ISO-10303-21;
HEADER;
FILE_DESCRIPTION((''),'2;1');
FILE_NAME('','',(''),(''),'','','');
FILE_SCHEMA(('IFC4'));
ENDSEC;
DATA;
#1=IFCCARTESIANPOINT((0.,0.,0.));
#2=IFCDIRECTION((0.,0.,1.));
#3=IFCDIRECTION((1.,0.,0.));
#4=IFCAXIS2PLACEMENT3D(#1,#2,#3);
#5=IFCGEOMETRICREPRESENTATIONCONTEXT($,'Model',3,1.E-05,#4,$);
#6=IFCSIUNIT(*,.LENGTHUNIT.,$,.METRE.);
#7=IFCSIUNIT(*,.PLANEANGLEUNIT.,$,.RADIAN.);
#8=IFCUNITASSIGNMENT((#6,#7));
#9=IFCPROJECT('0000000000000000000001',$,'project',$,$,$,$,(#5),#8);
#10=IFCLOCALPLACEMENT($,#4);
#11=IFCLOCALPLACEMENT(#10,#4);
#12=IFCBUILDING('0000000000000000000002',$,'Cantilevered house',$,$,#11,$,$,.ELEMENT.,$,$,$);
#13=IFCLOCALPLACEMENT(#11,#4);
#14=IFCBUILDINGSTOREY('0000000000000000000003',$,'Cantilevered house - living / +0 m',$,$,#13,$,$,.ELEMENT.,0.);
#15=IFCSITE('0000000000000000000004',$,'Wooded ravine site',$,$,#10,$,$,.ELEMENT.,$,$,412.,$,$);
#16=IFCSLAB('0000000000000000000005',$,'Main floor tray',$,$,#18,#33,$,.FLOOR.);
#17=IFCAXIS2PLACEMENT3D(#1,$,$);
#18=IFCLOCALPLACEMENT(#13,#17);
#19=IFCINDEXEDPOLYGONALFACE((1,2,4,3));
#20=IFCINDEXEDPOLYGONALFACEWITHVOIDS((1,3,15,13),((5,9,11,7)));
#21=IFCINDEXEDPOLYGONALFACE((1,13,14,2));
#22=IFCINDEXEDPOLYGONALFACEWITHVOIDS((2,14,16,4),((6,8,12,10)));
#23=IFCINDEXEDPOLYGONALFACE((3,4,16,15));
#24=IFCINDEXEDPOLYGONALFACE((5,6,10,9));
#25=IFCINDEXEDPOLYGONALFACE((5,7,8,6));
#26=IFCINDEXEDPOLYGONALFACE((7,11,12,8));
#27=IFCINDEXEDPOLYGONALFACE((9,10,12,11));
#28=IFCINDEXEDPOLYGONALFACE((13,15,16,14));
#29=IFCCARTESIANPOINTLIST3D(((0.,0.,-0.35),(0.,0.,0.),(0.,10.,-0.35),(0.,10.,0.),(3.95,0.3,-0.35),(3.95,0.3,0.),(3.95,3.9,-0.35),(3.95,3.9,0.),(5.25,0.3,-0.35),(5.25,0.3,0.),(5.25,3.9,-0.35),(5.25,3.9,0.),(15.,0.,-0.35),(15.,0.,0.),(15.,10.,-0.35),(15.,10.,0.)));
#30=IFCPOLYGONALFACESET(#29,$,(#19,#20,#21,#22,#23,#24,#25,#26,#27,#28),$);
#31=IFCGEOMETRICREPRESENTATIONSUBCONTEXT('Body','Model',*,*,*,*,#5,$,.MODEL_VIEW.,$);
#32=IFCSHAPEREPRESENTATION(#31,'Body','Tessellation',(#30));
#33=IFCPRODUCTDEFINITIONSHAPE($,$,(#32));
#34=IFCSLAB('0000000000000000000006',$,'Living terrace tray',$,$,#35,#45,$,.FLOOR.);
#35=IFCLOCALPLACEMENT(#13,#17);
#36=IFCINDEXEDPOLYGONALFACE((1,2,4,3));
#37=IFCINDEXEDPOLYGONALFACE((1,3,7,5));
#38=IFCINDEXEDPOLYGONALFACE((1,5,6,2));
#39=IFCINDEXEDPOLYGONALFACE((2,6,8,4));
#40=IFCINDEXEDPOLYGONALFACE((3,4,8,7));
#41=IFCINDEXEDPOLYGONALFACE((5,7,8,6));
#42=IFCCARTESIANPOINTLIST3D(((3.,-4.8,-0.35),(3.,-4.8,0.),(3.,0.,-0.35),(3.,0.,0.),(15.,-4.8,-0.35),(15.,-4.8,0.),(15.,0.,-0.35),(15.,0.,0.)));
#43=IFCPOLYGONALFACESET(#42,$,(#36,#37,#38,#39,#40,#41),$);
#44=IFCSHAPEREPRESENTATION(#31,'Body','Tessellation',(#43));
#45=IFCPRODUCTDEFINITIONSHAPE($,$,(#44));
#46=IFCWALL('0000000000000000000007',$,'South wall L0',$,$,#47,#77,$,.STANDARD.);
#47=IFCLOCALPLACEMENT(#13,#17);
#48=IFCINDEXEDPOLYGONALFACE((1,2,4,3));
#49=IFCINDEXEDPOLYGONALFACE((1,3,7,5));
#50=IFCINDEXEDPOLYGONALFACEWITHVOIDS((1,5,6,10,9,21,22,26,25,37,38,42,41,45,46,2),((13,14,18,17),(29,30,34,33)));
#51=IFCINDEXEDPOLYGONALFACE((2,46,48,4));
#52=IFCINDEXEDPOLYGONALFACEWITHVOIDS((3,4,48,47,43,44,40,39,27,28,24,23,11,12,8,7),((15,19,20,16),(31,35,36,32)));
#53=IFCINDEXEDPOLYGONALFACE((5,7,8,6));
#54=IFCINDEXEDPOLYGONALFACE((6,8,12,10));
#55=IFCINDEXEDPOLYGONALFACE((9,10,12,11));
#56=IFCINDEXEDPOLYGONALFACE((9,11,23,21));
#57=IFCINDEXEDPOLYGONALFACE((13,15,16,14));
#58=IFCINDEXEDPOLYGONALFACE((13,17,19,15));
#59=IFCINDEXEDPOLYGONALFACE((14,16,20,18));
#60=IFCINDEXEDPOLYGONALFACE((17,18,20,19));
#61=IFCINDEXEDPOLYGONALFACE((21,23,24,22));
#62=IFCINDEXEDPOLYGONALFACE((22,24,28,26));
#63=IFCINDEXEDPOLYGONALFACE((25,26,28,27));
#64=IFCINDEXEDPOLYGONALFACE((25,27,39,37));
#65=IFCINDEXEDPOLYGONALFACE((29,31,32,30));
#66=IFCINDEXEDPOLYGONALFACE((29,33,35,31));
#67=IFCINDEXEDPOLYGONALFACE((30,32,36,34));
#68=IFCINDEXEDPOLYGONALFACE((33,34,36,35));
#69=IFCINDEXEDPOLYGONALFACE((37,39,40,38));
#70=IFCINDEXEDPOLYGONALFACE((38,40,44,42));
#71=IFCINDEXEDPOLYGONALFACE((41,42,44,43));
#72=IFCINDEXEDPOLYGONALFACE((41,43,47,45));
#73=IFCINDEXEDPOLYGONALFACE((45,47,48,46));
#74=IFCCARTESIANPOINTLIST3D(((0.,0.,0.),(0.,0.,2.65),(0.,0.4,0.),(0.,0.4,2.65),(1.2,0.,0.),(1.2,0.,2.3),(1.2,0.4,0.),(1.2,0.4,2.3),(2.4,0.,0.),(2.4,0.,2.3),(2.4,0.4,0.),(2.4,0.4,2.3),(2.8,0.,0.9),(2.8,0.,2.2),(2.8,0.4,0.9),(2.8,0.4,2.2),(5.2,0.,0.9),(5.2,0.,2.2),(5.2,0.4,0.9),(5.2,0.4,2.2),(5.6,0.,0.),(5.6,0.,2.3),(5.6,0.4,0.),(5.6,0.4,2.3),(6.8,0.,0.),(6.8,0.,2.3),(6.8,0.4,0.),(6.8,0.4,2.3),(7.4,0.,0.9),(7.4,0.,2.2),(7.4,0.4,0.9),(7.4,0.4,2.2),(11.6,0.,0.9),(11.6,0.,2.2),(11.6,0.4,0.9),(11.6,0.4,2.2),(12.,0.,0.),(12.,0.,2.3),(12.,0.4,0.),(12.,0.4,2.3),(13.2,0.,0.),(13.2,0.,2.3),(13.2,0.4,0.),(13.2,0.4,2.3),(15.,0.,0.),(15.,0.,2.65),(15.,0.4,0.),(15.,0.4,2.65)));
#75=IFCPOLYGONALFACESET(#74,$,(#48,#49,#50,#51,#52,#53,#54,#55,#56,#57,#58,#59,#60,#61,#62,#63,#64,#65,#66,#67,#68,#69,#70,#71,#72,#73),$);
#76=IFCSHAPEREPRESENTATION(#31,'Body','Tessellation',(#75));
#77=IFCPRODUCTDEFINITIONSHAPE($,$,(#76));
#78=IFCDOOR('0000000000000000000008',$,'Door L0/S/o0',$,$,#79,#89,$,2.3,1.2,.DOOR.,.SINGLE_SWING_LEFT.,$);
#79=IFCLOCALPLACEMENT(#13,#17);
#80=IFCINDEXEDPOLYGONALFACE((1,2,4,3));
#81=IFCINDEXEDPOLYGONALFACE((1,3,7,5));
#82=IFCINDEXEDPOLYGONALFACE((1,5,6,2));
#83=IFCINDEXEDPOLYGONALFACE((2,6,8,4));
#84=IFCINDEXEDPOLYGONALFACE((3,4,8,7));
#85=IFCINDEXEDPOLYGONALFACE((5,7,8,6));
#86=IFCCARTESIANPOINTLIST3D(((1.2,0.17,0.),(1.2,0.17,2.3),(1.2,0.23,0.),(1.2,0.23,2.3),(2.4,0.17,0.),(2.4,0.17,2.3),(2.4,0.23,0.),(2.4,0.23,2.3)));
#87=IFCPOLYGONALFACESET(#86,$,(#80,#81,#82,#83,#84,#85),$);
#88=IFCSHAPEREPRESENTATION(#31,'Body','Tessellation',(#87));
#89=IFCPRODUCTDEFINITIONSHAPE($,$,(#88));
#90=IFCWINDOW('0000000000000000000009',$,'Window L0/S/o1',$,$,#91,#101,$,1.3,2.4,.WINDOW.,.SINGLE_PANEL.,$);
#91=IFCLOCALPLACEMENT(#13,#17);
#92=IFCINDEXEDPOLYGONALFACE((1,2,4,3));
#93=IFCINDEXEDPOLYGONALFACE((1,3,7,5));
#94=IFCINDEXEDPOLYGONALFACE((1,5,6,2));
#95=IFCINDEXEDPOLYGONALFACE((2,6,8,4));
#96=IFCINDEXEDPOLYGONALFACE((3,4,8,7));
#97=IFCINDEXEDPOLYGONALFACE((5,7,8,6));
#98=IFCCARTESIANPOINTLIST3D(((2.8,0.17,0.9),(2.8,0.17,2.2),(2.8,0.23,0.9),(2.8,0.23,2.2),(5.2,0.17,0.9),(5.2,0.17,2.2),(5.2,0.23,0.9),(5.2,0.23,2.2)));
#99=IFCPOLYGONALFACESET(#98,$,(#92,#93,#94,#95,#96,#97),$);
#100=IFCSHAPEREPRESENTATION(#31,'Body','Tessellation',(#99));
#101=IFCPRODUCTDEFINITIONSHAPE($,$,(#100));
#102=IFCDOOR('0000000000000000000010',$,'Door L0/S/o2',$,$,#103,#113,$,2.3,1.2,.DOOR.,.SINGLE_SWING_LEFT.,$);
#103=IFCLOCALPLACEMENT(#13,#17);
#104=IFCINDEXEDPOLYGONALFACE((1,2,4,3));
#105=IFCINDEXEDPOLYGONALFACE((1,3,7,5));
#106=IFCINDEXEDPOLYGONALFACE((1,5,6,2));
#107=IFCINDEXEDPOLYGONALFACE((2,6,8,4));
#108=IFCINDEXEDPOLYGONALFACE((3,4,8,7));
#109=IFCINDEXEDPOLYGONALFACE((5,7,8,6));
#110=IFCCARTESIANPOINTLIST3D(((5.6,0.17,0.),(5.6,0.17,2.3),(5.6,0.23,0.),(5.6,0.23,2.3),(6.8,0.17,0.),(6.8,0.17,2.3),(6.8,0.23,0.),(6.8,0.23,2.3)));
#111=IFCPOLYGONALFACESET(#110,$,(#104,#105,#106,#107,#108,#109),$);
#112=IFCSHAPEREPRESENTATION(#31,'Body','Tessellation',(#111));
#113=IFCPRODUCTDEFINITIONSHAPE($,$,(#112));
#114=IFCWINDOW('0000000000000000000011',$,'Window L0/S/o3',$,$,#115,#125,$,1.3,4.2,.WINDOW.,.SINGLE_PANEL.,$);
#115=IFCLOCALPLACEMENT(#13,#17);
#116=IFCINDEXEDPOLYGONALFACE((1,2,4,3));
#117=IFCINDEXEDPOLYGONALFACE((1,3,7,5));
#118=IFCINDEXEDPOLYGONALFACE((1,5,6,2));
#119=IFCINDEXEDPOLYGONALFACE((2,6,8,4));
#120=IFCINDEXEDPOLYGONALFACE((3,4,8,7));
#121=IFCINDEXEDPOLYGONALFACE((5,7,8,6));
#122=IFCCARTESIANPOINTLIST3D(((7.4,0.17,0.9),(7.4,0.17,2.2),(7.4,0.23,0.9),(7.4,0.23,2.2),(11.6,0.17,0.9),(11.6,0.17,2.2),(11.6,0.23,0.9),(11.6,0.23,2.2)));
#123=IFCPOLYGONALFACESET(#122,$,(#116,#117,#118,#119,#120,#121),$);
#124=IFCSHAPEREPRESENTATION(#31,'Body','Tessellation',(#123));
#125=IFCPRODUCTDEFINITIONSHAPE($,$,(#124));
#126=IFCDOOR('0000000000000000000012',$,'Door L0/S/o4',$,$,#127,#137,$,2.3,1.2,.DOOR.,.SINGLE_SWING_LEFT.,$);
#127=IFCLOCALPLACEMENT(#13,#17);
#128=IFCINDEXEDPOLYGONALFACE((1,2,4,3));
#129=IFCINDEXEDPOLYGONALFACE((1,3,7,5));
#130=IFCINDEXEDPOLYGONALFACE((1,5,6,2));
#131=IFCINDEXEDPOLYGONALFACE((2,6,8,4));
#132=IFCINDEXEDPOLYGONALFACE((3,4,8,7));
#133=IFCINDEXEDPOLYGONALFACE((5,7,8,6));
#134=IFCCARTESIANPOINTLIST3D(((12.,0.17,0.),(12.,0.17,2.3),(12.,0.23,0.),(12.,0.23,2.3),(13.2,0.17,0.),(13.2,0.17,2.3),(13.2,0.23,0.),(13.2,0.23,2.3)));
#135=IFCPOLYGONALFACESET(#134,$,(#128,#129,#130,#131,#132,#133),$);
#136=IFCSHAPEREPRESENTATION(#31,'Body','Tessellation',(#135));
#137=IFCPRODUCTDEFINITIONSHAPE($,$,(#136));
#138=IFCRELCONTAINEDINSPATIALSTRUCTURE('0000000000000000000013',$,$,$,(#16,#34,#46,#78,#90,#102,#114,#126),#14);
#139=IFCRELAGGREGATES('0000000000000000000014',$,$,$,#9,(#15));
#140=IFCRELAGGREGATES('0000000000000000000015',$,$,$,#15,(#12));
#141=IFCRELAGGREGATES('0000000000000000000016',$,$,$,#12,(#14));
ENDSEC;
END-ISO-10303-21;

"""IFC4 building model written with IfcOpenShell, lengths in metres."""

from ifc_helpers import new_model, si_unit, frame, frame_2d, origin_with_axes, place, context, subcontext, project, spatial, rectangle, extrude, element, fill, save


model = new_model("IFC4")

# Units and contexts
model_context = context("Model", 3, precision=1e-05, world=origin_with_axes())
body_context = subcontext(model_context, "Body", "Model", "MODEL_VIEW")
ifc_project = project(units=[si_unit("LENGTHUNIT", "METRE"), si_unit("PLANEANGLEUNIT", "RADIAN")], contexts=[model_context])

# Site, building, storey
site_placement = place(None, origin_with_axes())
site = spatial("IfcSite", under=ifc_project, at=site_placement, Name="Wooded ravine site", CompositionType="ELEMENT", RefElevation=412.0)
building_placement = place(site_placement, origin_with_axes())
building = spatial("IfcBuilding", under=site, at=building_placement, Name="Cantilevered house", CompositionType="ELEMENT")
storey_placement = place(building_placement, origin_with_axes())
storey = spatial("IfcBuildingStorey", under=building, at=storey_placement, Name="Cantilevered house - living / +0 m", CompositionType="ELEMENT", Elevation=0.0)

# Slab, opening
slab_1_placement = place(storey_placement, origin_with_axes())
slab_1 = element("IfcSlab", 1, at=slab_1_placement, inside=storey, Name="Main floor tray", PredefinedType="FLOOR", context=body_context, shape_type="SweptSolid", body=[
    extrude(rectangle(XDim=15.0, YDim=10.0, at=frame_2d((7.5, 5.0))), frame((0.0, 0.0, -0.35), z_axis=(0.0, 0.0, 1.0), x_axis=(1.0, 0.0, 0.0)), (0.0, 0.0, 1.0), 0.35),
])
opening_1_placement = place(storey_placement, origin_with_axes())
element("IfcOpeningElement", 2, at=opening_1_placement, inside=storey, cuts=slab_1, PredefinedType="OPENING", context=body_context, shape_type="SweptSolid", body=[
    extrude(rectangle(XDim=1.3, YDim=3.6, at=frame_2d((4.6, 2.1))), frame((0.0, 0.0, -0.37), z_axis=(0.0, 0.0, 1.0), x_axis=(1.0, 0.0, 0.0)), (0.0, 0.0, 1.0), 0.39),
])

# Slab
slab_2_placement = place(storey_placement, origin_with_axes())
element("IfcSlab", 3, at=slab_2_placement, inside=storey, Name="Living terrace tray", PredefinedType="FLOOR", context=body_context, shape_type="SweptSolid", body=[
    extrude(rectangle(XDim=12.0, YDim=4.8, at=frame_2d((9.0, -2.4))), frame((0.0, 0.0, -0.35), z_axis=(0.0, 0.0, 1.0), x_axis=(1.0, 0.0, 0.0)), (0.0, 0.0, 1.0), 0.35),
])

# Wall, openings, doors, windows
wall_1_placement = place(storey_placement, origin_with_axes())
wall_1 = element("IfcWall", 4, at=wall_1_placement, inside=storey, Name="South wall L0", PredefinedType="STANDARD", context=body_context, shape_type="SweptSolid", body=[
    extrude(rectangle(XDim=15.0, YDim=0.4, at=frame_2d((7.5, 0.2))), origin_with_axes(), (0.0, 0.0, 1.0), 2.65),
])
opening_2_placement = place(storey_placement, origin_with_axes())
opening_2 = element("IfcOpeningElement", 5, at=opening_2_placement, inside=storey, cuts=wall_1, PredefinedType="OPENING", context=body_context, shape_type="SweptSolid", body=[
    extrude(rectangle(XDim=1.2, YDim=0.44, at=frame_2d((1.8, 0.2))), origin_with_axes(), (0.0, 0.0, 1.0), 2.3),
])
opening_3_placement = place(storey_placement, origin_with_axes())
opening_3 = element("IfcOpeningElement", 6, at=opening_3_placement, inside=storey, cuts=wall_1, PredefinedType="OPENING", context=body_context, shape_type="SweptSolid", body=[
    extrude(rectangle(XDim=2.4, YDim=0.44, at=frame_2d((4.0, 0.2))), frame((0.0, 0.0, 0.9), z_axis=(0.0, 0.0, 1.0), x_axis=(1.0, 0.0, 0.0)), (0.0, 0.0, 1.0), 1.3),
])
opening_4_placement = place(storey_placement, origin_with_axes())
opening_4 = element("IfcOpeningElement", 7, at=opening_4_placement, inside=storey, cuts=wall_1, PredefinedType="OPENING", context=body_context, shape_type="SweptSolid", body=[
    extrude(rectangle(XDim=1.2, YDim=0.44, at=frame_2d((6.2, 0.2))), origin_with_axes(), (0.0, 0.0, 1.0), 2.3),
])
opening_5_placement = place(storey_placement, origin_with_axes())
opening_5 = element("IfcOpeningElement", 8, at=opening_5_placement, inside=storey, cuts=wall_1, PredefinedType="OPENING", context=body_context, shape_type="SweptSolid", body=[
    extrude(rectangle(XDim=4.2, YDim=0.44, at=frame_2d((9.5, 0.2))), frame((0.0, 0.0, 0.9), z_axis=(0.0, 0.0, 1.0), x_axis=(1.0, 0.0, 0.0)), (0.0, 0.0, 1.0), 1.3),
])
opening_6_placement = place(storey_placement, origin_with_axes())
opening_6 = element("IfcOpeningElement", 9, at=opening_6_placement, inside=storey, cuts=wall_1, PredefinedType="OPENING", context=body_context, shape_type="SweptSolid", body=[
    extrude(rectangle(XDim=1.2, YDim=0.44, at=frame_2d((12.6, 0.2))), origin_with_axes(), (0.0, 0.0, 1.0), 2.3),
])
door_1_placement = place(storey_placement, origin_with_axes())
door_1 = element("IfcDoor", 10, at=door_1_placement, inside=storey, Name="Door L0/S/o0", OperationType="SINGLE_SWING_LEFT", OverallHeight=2.3, OverallWidth=1.2, PredefinedType="DOOR", context=body_context, shape_type="SweptSolid", body=[
    extrude(rectangle(XDim=1.2, YDim=0.06, at=frame_2d((1.8, 0.2))), origin_with_axes(), (0.0, 0.0, 1.0), 2.3),
])
fill(opening_2, door_1)
window_1_placement = place(storey_placement, origin_with_axes())
window_1 = element("IfcWindow", 11, at=window_1_placement, inside=storey, Name="Window L0/S/o1", OverallHeight=1.3, OverallWidth=2.4, PartitioningType="SINGLE_PANEL", PredefinedType="WINDOW", context=body_context, shape_type="SweptSolid", body=[
    extrude(rectangle(XDim=2.4, YDim=0.06, at=frame_2d((4.0, 0.2))), frame((0.0, 0.0, 0.9), z_axis=(0.0, 0.0, 1.0), x_axis=(1.0, 0.0, 0.0)), (0.0, 0.0, 1.0), 1.3),
])
fill(opening_3, window_1)
door_2_placement = place(storey_placement, origin_with_axes())
door_2 = element("IfcDoor", 12, at=door_2_placement, inside=storey, Name="Door L0/S/o2", OperationType="SINGLE_SWING_LEFT", OverallHeight=2.3, OverallWidth=1.2, PredefinedType="DOOR", context=body_context, shape_type="SweptSolid", body=[
    extrude(rectangle(XDim=1.2, YDim=0.06, at=frame_2d((6.2, 0.2))), origin_with_axes(), (0.0, 0.0, 1.0), 2.3),
])
fill(opening_4, door_2)
window_2_placement = place(storey_placement, origin_with_axes())
window_2 = element("IfcWindow", 13, at=window_2_placement, inside=storey, Name="Window L0/S/o3", OverallHeight=1.3, OverallWidth=4.2, PartitioningType="SINGLE_PANEL", PredefinedType="WINDOW", context=body_context, shape_type="SweptSolid", body=[
    extrude(rectangle(XDim=4.2, YDim=0.06, at=frame_2d((9.5, 0.2))), frame((0.0, 0.0, 0.9), z_axis=(0.0, 0.0, 1.0), x_axis=(1.0, 0.0, 0.0)), (0.0, 0.0, 1.0), 1.3),
])
fill(opening_5, window_2)
door_3_placement = place(storey_placement, origin_with_axes())
door_3 = element("IfcDoor", 14, at=door_3_placement, inside=storey, Name="Door L0/S/o4", OperationType="SINGLE_SWING_LEFT", OverallHeight=2.3, OverallWidth=1.2, PredefinedType="DOOR", context=body_context, shape_type="SweptSolid", body=[
    extrude(rectangle(XDim=1.2, YDim=0.06, at=frame_2d((12.6, 0.2))), origin_with_axes(), (0.0, 0.0, 1.0), 2.3),
])
fill(opening_6, door_3)

save(model, "model.ifc")
